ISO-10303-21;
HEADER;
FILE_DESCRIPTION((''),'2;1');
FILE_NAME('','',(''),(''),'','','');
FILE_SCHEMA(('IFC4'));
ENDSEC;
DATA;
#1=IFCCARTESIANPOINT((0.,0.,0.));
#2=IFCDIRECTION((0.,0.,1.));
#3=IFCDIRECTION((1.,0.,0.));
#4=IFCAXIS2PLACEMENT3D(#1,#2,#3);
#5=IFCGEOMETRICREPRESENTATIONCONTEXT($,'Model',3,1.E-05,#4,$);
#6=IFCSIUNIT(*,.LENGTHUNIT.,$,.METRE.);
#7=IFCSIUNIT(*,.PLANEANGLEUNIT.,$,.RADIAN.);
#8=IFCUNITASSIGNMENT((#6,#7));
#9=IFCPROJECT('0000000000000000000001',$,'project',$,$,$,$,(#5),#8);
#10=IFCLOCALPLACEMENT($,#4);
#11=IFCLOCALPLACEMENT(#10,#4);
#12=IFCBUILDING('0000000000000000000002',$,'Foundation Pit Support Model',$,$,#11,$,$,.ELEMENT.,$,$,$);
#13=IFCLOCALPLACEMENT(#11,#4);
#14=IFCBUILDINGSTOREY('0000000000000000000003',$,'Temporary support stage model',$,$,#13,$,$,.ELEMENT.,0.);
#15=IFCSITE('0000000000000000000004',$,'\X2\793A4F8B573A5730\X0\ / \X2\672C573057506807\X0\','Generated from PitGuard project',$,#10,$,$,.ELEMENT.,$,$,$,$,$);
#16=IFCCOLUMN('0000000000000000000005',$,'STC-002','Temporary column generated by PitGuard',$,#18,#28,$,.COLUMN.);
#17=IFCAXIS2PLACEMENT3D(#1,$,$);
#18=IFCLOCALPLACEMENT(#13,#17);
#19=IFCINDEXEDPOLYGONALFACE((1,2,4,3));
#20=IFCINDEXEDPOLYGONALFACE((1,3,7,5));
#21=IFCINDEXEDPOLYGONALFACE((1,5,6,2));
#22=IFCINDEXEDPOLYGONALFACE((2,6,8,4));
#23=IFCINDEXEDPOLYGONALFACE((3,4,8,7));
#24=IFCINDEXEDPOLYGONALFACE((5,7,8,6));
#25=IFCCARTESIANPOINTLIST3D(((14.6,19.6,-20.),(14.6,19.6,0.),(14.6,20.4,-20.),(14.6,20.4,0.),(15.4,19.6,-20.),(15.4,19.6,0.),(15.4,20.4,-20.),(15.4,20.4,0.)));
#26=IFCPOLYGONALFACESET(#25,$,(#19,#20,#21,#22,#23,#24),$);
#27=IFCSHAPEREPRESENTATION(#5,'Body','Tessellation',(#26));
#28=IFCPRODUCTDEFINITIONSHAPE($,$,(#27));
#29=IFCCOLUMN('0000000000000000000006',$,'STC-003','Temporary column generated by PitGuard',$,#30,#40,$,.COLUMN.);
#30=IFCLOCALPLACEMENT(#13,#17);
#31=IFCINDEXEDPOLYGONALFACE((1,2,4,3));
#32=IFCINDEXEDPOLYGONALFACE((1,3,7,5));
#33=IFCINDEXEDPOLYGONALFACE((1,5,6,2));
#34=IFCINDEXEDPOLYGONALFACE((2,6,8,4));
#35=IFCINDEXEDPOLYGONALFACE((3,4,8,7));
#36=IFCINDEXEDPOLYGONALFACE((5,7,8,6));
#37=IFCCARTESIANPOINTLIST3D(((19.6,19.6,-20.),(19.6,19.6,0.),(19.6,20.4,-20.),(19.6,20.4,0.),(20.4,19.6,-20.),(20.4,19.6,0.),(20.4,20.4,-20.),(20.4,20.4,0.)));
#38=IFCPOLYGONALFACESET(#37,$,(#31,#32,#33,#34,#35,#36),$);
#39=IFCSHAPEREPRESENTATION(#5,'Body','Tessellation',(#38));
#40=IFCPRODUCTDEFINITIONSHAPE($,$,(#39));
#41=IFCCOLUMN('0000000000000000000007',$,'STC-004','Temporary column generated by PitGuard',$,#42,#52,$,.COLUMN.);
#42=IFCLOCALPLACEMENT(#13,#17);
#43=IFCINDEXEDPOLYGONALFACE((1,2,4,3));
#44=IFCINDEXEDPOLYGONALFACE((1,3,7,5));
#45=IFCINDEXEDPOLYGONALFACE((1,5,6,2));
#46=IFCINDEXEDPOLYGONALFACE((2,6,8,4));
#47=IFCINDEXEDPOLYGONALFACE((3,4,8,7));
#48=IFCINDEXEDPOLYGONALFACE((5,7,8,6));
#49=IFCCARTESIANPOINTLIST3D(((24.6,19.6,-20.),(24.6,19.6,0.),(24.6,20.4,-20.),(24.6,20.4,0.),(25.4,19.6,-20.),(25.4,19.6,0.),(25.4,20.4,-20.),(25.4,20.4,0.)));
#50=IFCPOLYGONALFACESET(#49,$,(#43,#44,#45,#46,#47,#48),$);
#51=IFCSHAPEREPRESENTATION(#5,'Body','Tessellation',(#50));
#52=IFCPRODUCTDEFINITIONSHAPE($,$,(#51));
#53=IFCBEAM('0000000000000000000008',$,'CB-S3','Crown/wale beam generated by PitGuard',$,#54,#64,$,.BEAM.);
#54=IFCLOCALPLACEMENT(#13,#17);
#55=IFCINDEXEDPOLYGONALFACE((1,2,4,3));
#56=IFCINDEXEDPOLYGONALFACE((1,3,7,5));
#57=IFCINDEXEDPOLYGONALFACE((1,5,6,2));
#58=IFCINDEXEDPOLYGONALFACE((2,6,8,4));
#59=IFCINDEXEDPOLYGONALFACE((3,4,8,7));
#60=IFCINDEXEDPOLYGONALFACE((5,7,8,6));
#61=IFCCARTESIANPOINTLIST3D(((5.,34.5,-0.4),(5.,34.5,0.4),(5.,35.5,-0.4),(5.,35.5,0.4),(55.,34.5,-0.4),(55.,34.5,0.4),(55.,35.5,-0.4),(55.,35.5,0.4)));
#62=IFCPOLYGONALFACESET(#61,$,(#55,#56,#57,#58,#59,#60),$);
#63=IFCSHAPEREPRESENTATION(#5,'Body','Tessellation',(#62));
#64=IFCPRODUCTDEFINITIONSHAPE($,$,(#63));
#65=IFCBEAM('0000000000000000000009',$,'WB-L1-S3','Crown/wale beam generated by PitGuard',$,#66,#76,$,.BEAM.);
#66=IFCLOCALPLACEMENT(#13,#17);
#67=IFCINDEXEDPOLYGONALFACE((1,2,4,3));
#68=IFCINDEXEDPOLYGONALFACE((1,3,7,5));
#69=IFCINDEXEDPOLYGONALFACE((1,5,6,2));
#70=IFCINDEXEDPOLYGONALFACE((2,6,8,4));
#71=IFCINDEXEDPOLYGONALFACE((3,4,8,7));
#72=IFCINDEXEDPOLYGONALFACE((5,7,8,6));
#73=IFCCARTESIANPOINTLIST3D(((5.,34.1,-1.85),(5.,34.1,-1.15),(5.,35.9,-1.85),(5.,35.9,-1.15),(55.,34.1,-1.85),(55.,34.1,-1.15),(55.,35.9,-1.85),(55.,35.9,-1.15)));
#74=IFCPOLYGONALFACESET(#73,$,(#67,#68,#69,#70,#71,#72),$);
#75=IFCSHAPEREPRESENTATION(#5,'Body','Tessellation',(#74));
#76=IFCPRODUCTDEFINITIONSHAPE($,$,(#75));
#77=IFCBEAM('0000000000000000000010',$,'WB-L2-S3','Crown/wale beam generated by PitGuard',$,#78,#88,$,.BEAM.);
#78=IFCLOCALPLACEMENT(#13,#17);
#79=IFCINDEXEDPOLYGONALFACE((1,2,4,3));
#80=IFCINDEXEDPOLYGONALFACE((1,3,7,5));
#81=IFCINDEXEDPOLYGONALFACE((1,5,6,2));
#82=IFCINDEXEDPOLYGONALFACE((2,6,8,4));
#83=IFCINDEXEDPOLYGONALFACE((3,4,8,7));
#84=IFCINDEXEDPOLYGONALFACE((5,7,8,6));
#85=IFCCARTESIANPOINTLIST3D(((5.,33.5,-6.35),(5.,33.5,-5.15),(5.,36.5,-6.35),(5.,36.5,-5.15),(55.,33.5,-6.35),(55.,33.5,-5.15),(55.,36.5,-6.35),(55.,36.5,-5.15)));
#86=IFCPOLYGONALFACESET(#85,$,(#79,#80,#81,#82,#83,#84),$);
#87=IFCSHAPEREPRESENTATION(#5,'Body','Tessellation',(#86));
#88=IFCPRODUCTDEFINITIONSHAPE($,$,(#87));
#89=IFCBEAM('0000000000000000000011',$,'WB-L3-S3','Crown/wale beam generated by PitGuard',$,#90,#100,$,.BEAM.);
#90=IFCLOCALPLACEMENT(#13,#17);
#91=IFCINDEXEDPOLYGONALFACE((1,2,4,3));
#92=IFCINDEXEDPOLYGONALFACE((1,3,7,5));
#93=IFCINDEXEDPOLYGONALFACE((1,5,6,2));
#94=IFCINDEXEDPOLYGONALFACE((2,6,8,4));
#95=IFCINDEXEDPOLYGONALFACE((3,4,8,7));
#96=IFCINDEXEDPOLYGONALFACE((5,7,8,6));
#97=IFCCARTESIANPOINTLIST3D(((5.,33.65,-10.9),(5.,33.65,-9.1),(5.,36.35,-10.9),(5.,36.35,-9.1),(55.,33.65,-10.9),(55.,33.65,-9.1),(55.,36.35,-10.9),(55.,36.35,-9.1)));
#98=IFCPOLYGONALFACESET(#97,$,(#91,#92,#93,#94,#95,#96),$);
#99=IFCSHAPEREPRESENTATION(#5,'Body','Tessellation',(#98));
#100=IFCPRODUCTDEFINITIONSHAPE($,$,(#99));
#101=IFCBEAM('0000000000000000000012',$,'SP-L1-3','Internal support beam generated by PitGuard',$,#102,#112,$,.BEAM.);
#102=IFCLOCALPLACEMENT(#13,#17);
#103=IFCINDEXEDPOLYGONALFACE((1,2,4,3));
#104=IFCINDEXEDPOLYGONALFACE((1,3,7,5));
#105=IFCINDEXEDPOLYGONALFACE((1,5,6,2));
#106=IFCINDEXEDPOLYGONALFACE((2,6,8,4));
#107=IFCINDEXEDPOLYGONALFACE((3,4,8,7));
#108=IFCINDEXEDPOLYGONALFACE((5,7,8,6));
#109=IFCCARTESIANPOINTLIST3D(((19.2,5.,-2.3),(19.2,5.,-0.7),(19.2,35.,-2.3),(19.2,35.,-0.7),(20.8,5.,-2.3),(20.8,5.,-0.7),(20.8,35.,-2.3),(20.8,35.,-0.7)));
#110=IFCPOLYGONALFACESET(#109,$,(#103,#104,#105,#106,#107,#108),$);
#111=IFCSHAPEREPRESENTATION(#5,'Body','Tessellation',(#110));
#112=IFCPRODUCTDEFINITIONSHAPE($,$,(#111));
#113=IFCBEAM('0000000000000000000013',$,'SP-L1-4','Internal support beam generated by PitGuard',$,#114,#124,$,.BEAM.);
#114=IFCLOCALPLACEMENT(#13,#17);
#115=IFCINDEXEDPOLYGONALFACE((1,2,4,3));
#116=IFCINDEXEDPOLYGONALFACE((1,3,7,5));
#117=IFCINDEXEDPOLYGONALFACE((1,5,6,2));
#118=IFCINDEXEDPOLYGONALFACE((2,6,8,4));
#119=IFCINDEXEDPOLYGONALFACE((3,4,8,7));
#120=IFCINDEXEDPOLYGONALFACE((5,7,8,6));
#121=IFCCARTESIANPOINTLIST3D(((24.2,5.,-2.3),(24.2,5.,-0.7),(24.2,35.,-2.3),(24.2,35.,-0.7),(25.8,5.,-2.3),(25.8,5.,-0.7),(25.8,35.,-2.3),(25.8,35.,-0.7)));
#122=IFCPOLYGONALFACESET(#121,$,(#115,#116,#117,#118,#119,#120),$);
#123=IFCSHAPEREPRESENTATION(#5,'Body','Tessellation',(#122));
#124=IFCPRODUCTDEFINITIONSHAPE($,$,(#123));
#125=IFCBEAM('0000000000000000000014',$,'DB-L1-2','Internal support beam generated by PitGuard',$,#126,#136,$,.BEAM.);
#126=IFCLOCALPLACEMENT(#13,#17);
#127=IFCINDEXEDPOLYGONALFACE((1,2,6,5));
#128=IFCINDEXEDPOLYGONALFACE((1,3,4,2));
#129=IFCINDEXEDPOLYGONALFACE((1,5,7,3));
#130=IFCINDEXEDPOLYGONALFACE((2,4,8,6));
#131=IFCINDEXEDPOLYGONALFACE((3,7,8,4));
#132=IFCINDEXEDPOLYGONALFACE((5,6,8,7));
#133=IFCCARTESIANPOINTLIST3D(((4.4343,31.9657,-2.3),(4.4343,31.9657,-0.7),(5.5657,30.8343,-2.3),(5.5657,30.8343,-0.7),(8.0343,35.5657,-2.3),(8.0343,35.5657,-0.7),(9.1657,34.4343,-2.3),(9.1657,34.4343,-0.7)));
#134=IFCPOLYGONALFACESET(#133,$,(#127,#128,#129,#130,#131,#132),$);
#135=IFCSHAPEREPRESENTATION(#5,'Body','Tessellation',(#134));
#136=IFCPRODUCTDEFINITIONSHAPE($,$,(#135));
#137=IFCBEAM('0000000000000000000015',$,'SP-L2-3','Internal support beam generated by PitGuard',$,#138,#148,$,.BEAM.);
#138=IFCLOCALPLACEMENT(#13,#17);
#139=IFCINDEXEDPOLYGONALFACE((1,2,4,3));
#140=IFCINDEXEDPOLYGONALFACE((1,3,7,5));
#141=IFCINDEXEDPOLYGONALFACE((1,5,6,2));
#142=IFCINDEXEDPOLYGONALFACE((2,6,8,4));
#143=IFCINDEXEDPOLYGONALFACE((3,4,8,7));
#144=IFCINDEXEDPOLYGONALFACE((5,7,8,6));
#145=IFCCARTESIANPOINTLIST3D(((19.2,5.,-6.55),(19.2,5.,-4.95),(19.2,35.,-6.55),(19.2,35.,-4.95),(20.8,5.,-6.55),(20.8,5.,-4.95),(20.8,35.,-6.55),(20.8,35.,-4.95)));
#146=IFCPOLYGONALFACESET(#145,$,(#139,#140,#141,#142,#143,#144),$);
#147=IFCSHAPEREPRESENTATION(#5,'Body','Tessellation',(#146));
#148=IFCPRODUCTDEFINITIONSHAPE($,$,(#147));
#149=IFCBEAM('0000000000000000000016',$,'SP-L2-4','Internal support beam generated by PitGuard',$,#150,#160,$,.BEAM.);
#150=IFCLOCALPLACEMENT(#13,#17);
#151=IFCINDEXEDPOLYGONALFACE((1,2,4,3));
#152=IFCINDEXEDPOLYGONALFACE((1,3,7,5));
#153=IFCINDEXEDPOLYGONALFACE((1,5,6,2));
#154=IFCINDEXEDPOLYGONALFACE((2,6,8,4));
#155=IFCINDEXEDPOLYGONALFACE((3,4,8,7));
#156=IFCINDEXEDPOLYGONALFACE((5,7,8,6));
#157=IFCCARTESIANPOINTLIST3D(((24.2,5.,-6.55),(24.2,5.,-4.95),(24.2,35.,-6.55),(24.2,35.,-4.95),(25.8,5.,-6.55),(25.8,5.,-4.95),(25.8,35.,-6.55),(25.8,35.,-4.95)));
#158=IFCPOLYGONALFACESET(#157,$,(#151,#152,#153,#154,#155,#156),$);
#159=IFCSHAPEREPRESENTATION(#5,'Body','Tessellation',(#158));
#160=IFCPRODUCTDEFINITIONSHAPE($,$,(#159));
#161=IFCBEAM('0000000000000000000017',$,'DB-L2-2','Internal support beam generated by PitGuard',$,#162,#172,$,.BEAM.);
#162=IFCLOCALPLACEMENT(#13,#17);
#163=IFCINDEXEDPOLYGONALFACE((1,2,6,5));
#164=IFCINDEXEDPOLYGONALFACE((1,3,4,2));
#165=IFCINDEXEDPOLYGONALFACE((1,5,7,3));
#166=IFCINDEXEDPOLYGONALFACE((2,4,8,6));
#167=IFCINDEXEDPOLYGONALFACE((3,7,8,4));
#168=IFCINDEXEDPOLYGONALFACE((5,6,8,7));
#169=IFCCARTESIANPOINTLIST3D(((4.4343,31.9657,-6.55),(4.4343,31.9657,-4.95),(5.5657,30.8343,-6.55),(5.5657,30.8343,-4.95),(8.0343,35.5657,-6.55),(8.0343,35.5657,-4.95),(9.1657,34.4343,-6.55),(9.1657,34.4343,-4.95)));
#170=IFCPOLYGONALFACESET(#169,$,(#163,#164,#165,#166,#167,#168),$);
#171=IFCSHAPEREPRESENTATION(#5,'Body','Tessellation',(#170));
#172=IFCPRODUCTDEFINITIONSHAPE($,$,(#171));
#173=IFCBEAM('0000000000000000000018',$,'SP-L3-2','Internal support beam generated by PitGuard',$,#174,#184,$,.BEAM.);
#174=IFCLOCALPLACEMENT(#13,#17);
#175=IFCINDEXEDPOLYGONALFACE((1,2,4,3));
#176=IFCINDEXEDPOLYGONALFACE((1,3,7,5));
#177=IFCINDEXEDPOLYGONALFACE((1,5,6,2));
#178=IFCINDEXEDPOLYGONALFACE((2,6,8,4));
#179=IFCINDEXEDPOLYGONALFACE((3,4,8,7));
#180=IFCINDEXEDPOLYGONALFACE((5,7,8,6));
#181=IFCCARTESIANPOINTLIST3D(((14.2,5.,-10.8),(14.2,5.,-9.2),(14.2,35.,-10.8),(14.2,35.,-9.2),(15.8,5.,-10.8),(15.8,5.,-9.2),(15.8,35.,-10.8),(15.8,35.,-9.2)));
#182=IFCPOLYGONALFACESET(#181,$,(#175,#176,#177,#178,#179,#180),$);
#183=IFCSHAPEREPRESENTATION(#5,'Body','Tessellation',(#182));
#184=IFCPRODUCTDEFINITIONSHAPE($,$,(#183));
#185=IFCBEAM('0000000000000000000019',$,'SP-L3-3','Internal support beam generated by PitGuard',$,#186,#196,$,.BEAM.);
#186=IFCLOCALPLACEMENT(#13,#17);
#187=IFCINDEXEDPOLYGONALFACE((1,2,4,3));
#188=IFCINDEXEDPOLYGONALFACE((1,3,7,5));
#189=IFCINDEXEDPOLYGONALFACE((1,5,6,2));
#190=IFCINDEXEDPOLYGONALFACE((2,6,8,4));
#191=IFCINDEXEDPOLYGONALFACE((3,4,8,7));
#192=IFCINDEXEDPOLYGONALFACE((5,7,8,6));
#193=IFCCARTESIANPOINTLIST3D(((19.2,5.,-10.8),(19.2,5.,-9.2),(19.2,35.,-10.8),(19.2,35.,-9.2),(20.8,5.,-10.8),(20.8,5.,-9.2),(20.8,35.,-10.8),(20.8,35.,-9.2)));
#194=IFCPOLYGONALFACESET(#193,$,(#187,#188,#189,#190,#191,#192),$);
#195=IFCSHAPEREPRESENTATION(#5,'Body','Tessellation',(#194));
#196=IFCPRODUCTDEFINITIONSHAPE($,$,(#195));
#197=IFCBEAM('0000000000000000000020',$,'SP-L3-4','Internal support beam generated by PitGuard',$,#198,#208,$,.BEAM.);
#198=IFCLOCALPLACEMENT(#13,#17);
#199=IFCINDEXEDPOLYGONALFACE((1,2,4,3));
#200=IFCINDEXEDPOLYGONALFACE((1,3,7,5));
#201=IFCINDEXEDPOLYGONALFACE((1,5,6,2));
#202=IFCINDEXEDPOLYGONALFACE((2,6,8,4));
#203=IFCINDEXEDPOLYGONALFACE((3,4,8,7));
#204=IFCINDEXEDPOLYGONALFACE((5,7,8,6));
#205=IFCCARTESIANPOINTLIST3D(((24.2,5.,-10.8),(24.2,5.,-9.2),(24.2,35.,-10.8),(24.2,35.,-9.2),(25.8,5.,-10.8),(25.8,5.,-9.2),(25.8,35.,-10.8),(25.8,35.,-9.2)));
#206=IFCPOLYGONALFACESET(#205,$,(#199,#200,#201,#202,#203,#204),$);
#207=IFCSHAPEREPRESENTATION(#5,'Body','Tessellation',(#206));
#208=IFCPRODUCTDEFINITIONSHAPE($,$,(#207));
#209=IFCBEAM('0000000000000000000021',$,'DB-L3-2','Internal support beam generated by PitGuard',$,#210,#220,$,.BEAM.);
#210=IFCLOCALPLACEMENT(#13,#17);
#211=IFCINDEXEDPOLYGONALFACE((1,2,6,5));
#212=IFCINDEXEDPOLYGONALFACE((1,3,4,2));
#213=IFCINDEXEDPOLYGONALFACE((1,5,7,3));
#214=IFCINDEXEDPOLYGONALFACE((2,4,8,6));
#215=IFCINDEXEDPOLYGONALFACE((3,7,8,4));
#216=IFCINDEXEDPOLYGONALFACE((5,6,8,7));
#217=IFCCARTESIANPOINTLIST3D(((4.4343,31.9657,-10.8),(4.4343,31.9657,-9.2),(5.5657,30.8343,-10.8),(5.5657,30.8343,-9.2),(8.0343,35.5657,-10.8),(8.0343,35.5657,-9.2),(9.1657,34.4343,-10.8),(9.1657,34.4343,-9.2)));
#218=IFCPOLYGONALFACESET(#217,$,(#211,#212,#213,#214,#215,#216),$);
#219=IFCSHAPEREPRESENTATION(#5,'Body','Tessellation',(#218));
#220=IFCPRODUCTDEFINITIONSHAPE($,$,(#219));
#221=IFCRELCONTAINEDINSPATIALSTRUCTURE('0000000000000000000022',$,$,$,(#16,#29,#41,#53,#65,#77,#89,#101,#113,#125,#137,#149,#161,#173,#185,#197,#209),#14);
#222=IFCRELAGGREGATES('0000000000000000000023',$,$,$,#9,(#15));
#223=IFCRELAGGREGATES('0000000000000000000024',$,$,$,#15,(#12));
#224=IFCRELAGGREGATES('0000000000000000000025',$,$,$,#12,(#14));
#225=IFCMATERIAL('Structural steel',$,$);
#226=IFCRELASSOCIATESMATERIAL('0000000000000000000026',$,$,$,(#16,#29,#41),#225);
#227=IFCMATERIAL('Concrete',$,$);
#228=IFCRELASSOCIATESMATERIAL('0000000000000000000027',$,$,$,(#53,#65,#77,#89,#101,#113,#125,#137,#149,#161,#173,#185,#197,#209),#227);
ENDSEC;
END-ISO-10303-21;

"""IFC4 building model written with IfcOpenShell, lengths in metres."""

from ifc_helpers import new_model, si_unit, frame, origin_with_axes, origin_2d, place, context, project, spatial, rectangle, extrude, material, element, save


model = new_model("IFC4")

# Units and contexts
model_context = context("Model", 3, precision=1e-05, world=origin_with_axes())
ifc_project = project(units=[si_unit("LENGTHUNIT", "METRE"), si_unit("PLANEANGLEUNIT", "RADIAN")], contexts=[model_context])

# Site, building, storey
site_placement = place(None, origin_with_axes())
site = spatial("IfcSite", under=ifc_project, at=site_placement, Name="示例场地 / 本地坐标", Description="Generated from PitGuard project", CompositionType="ELEMENT")
building_placement = place(site_placement, origin_with_axes())
building = spatial("IfcBuilding", under=site, at=building_placement, Name="Foundation Pit Support Model", CompositionType="ELEMENT")
storey_placement = place(building_placement, origin_with_axes())
storey = spatial("IfcBuildingStorey", under=building, at=storey_placement, Name="Temporary support stage model", CompositionType="ELEMENT", Elevation=0.0)

# Columns
ifc_material_1 = material(Name="Structural steel")
for number, where, z_axis, x_axis, name in (
    (1, (15.0, 20.0, -20.0), (0.0, 0.0, 1.0), (1.0, 0.0, 0.0), "STC-002"),
    (2, (20.0, 20.0, -20.0), (0.0, 0.0, 1.0), (1.0, 0.0, 0.0), "STC-003"),
    (3, (25.0, 20.0, -20.0), (0.0, 0.0, 1.0), (1.0, 0.0, 0.0), "STC-004"),
):
    element("IfcColumn", number, at=place(storey_placement, frame(where, z_axis=z_axis, x_axis=x_axis)), inside=storey, material=ifc_material_1, Name=name, Description="Temporary column generated by PitGuard", PredefinedType="COLUMN", context=model_context, shape_type="SweptSolid", body=[
        extrude(rectangle(XDim=0.8, YDim=0.8, at=origin_2d()), origin_with_axes(), (0.0, 0.0, 1.0), 20.0),
    ])

# Beams
ifc_material_2 = material(Name="Concrete")
beam_1_placement = place(storey_placement, frame((30.0, 35.0, -0.4), z_axis=(0.0, 0.0, 1.0), x_axis=(-1.0, 0.0, 0.0)))
element("IfcBeam", 4, at=beam_1_placement, inside=storey, material=ifc_material_2, Name="CB-S3", Description="Crown/wale beam generated by PitGuard", PredefinedType="BEAM", context=model_context, shape_type="SweptSolid", body=[
    extrude(rectangle(XDim=50.0, YDim=1.0, at=origin_2d()), origin_with_axes(), (0.0, 0.0, 1.0), 0.8),
])
beam_2_placement = place(storey_placement, frame((30.0, 35.0, -1.85), z_axis=(0.0, 0.0, 1.0), x_axis=(-1.0, 0.0, 0.0)))
element("IfcBeam", 5, at=beam_2_placement, inside=storey, material=ifc_material_2, Name="WB-L1-S3", Description="Crown/wale beam generated by PitGuard", PredefinedType="BEAM", context=model_context, shape_type="SweptSolid", body=[
    extrude(rectangle(XDim=50.0, YDim=1.8, at=origin_2d()), origin_with_axes(), (0.0, 0.0, 1.0), 0.7),
])
beam_3_placement = place(storey_placement, frame((30.0, 35.0, -6.35), z_axis=(0.0, 0.0, 1.0), x_axis=(-1.0, 0.0, 0.0)))
element("IfcBeam", 6, at=beam_3_placement, inside=storey, material=ifc_material_2, Name="WB-L2-S3", Description="Crown/wale beam generated by PitGuard", PredefinedType="BEAM", context=model_context, shape_type="SweptSolid", body=[
    extrude(rectangle(XDim=50.0, YDim=3.0, at=origin_2d()), origin_with_axes(), (0.0, 0.0, 1.0), 1.2),
])
beam_4_placement = place(storey_placement, frame((30.0, 35.0, -10.9), z_axis=(0.0, 0.0, 1.0), x_axis=(-1.0, 0.0, 0.0)))
element("IfcBeam", 7, at=beam_4_placement, inside=storey, material=ifc_material_2, Name="WB-L3-S3", Description="Crown/wale beam generated by PitGuard", PredefinedType="BEAM", context=model_context, shape_type="SweptSolid", body=[
    extrude(rectangle(XDim=50.0, YDim=2.7, at=origin_2d()), origin_with_axes(), (0.0, 0.0, 1.0), 1.8),
])
for number, where, z_axis, x_axis, name in (
    (8, (20.0, 20.0, -2.3), (0.0, 0.0, 1.0), (0.0, 1.0, 0.0), "SP-L1-3"),
    (9, (25.0, 20.0, -2.3), (0.0, 0.0, 1.0), (0.0, 1.0, 0.0), "SP-L1-4"),
):
    element("IfcBeam", number, at=place(storey_placement, frame(where, z_axis=z_axis, x_axis=x_axis)), inside=storey, material=ifc_material_2, Name=name, Description="Internal support beam generated by PitGuard", PredefinedType="BEAM", context=model_context, shape_type="SweptSolid", body=[
        extrude(rectangle(XDim=30.0, YDim=1.6, at=origin_2d()), origin_with_axes(), (0.0, 0.0, 1.0), 1.6),
    ])
beam_5_placement = place(storey_placement, frame((6.8, 33.2, -2.3), z_axis=(0.0, 0.0, 1.0), x_axis=(-0.707107, -0.707107, 0.0)))
element("IfcBeam", 10, at=beam_5_placement, inside=storey, material=ifc_material_2, Name="DB-L1-2", Description="Internal support beam generated by PitGuard", PredefinedType="BEAM", context=model_context, shape_type="SweptSolid", body=[
    extrude(rectangle(XDim=5.0912, YDim=1.6, at=origin_2d()), origin_with_axes(), (0.0, 0.0, 1.0), 1.6),
])
for number, where, z_axis, x_axis, name in (
    (11, (20.0, 20.0, -6.55), (0.0, 0.0, 1.0), (0.0, 1.0, 0.0), "SP-L2-3"),
    (12, (25.0, 20.0, -6.55), (0.0, 0.0, 1.0), (0.0, 1.0, 0.0), "SP-L2-4"),
):
    element("IfcBeam", number, at=place(storey_placement, frame(where, z_axis=z_axis, x_axis=x_axis)), inside=storey, material=ifc_material_2, Name=name, Description="Internal support beam generated by PitGuard", PredefinedType="BEAM", context=model_context, shape_type="SweptSolid", body=[
        extrude(rectangle(XDim=30.0, YDim=1.6, at=origin_2d()), origin_with_axes(), (0.0, 0.0, 1.0), 1.6),
    ])
beam_6_placement = place(storey_placement, frame((6.8, 33.2, -6.55), z_axis=(0.0, 0.0, 1.0), x_axis=(-0.707107, -0.707107, 0.0)))
element("IfcBeam", 13, at=beam_6_placement, inside=storey, material=ifc_material_2, Name="DB-L2-2", Description="Internal support beam generated by PitGuard", PredefinedType="BEAM", context=model_context, shape_type="SweptSolid", body=[
    extrude(rectangle(XDim=5.0912, YDim=1.6, at=origin_2d()), origin_with_axes(), (0.0, 0.0, 1.0), 1.6),
])
for number, where, z_axis, x_axis, name in (
    (14, (15.0, 20.0, -10.8), (0.0, 0.0, 1.0), (0.0, 1.0, 0.0), "SP-L3-2"),
    (15, (20.0, 20.0, -10.8), (0.0, 0.0, 1.0), (0.0, 1.0, 0.0), "SP-L3-3"),
    (16, (25.0, 20.0, -10.8), (0.0, 0.0, 1.0), (0.0, 1.0, 0.0), "SP-L3-4"),
):
    element("IfcBeam", number, at=place(storey_placement, frame(where, z_axis=z_axis, x_axis=x_axis)), inside=storey, material=ifc_material_2, Name=name, Description="Internal support beam generated by PitGuard", PredefinedType="BEAM", context=model_context, shape_type="SweptSolid", body=[
        extrude(rectangle(XDim=30.0, YDim=1.6, at=origin_2d()), origin_with_axes(), (0.0, 0.0, 1.0), 1.6),
    ])
beam_7_placement = place(storey_placement, frame((6.8, 33.2, -10.8), z_axis=(0.0, 0.0, 1.0), x_axis=(-0.707107, -0.707107, 0.0)))
element("IfcBeam", 17, at=beam_7_placement, inside=storey, material=ifc_material_2, Name="DB-L3-2", Description="Internal support beam generated by PitGuard", PredefinedType="BEAM", context=model_context, shape_type="SweptSolid", body=[
    extrude(rectangle(XDim=5.0912, YDim=1.6, at=origin_2d()), origin_with_axes(), (0.0, 0.0, 1.0), 1.6),
])

save(model, "model.ifc")
